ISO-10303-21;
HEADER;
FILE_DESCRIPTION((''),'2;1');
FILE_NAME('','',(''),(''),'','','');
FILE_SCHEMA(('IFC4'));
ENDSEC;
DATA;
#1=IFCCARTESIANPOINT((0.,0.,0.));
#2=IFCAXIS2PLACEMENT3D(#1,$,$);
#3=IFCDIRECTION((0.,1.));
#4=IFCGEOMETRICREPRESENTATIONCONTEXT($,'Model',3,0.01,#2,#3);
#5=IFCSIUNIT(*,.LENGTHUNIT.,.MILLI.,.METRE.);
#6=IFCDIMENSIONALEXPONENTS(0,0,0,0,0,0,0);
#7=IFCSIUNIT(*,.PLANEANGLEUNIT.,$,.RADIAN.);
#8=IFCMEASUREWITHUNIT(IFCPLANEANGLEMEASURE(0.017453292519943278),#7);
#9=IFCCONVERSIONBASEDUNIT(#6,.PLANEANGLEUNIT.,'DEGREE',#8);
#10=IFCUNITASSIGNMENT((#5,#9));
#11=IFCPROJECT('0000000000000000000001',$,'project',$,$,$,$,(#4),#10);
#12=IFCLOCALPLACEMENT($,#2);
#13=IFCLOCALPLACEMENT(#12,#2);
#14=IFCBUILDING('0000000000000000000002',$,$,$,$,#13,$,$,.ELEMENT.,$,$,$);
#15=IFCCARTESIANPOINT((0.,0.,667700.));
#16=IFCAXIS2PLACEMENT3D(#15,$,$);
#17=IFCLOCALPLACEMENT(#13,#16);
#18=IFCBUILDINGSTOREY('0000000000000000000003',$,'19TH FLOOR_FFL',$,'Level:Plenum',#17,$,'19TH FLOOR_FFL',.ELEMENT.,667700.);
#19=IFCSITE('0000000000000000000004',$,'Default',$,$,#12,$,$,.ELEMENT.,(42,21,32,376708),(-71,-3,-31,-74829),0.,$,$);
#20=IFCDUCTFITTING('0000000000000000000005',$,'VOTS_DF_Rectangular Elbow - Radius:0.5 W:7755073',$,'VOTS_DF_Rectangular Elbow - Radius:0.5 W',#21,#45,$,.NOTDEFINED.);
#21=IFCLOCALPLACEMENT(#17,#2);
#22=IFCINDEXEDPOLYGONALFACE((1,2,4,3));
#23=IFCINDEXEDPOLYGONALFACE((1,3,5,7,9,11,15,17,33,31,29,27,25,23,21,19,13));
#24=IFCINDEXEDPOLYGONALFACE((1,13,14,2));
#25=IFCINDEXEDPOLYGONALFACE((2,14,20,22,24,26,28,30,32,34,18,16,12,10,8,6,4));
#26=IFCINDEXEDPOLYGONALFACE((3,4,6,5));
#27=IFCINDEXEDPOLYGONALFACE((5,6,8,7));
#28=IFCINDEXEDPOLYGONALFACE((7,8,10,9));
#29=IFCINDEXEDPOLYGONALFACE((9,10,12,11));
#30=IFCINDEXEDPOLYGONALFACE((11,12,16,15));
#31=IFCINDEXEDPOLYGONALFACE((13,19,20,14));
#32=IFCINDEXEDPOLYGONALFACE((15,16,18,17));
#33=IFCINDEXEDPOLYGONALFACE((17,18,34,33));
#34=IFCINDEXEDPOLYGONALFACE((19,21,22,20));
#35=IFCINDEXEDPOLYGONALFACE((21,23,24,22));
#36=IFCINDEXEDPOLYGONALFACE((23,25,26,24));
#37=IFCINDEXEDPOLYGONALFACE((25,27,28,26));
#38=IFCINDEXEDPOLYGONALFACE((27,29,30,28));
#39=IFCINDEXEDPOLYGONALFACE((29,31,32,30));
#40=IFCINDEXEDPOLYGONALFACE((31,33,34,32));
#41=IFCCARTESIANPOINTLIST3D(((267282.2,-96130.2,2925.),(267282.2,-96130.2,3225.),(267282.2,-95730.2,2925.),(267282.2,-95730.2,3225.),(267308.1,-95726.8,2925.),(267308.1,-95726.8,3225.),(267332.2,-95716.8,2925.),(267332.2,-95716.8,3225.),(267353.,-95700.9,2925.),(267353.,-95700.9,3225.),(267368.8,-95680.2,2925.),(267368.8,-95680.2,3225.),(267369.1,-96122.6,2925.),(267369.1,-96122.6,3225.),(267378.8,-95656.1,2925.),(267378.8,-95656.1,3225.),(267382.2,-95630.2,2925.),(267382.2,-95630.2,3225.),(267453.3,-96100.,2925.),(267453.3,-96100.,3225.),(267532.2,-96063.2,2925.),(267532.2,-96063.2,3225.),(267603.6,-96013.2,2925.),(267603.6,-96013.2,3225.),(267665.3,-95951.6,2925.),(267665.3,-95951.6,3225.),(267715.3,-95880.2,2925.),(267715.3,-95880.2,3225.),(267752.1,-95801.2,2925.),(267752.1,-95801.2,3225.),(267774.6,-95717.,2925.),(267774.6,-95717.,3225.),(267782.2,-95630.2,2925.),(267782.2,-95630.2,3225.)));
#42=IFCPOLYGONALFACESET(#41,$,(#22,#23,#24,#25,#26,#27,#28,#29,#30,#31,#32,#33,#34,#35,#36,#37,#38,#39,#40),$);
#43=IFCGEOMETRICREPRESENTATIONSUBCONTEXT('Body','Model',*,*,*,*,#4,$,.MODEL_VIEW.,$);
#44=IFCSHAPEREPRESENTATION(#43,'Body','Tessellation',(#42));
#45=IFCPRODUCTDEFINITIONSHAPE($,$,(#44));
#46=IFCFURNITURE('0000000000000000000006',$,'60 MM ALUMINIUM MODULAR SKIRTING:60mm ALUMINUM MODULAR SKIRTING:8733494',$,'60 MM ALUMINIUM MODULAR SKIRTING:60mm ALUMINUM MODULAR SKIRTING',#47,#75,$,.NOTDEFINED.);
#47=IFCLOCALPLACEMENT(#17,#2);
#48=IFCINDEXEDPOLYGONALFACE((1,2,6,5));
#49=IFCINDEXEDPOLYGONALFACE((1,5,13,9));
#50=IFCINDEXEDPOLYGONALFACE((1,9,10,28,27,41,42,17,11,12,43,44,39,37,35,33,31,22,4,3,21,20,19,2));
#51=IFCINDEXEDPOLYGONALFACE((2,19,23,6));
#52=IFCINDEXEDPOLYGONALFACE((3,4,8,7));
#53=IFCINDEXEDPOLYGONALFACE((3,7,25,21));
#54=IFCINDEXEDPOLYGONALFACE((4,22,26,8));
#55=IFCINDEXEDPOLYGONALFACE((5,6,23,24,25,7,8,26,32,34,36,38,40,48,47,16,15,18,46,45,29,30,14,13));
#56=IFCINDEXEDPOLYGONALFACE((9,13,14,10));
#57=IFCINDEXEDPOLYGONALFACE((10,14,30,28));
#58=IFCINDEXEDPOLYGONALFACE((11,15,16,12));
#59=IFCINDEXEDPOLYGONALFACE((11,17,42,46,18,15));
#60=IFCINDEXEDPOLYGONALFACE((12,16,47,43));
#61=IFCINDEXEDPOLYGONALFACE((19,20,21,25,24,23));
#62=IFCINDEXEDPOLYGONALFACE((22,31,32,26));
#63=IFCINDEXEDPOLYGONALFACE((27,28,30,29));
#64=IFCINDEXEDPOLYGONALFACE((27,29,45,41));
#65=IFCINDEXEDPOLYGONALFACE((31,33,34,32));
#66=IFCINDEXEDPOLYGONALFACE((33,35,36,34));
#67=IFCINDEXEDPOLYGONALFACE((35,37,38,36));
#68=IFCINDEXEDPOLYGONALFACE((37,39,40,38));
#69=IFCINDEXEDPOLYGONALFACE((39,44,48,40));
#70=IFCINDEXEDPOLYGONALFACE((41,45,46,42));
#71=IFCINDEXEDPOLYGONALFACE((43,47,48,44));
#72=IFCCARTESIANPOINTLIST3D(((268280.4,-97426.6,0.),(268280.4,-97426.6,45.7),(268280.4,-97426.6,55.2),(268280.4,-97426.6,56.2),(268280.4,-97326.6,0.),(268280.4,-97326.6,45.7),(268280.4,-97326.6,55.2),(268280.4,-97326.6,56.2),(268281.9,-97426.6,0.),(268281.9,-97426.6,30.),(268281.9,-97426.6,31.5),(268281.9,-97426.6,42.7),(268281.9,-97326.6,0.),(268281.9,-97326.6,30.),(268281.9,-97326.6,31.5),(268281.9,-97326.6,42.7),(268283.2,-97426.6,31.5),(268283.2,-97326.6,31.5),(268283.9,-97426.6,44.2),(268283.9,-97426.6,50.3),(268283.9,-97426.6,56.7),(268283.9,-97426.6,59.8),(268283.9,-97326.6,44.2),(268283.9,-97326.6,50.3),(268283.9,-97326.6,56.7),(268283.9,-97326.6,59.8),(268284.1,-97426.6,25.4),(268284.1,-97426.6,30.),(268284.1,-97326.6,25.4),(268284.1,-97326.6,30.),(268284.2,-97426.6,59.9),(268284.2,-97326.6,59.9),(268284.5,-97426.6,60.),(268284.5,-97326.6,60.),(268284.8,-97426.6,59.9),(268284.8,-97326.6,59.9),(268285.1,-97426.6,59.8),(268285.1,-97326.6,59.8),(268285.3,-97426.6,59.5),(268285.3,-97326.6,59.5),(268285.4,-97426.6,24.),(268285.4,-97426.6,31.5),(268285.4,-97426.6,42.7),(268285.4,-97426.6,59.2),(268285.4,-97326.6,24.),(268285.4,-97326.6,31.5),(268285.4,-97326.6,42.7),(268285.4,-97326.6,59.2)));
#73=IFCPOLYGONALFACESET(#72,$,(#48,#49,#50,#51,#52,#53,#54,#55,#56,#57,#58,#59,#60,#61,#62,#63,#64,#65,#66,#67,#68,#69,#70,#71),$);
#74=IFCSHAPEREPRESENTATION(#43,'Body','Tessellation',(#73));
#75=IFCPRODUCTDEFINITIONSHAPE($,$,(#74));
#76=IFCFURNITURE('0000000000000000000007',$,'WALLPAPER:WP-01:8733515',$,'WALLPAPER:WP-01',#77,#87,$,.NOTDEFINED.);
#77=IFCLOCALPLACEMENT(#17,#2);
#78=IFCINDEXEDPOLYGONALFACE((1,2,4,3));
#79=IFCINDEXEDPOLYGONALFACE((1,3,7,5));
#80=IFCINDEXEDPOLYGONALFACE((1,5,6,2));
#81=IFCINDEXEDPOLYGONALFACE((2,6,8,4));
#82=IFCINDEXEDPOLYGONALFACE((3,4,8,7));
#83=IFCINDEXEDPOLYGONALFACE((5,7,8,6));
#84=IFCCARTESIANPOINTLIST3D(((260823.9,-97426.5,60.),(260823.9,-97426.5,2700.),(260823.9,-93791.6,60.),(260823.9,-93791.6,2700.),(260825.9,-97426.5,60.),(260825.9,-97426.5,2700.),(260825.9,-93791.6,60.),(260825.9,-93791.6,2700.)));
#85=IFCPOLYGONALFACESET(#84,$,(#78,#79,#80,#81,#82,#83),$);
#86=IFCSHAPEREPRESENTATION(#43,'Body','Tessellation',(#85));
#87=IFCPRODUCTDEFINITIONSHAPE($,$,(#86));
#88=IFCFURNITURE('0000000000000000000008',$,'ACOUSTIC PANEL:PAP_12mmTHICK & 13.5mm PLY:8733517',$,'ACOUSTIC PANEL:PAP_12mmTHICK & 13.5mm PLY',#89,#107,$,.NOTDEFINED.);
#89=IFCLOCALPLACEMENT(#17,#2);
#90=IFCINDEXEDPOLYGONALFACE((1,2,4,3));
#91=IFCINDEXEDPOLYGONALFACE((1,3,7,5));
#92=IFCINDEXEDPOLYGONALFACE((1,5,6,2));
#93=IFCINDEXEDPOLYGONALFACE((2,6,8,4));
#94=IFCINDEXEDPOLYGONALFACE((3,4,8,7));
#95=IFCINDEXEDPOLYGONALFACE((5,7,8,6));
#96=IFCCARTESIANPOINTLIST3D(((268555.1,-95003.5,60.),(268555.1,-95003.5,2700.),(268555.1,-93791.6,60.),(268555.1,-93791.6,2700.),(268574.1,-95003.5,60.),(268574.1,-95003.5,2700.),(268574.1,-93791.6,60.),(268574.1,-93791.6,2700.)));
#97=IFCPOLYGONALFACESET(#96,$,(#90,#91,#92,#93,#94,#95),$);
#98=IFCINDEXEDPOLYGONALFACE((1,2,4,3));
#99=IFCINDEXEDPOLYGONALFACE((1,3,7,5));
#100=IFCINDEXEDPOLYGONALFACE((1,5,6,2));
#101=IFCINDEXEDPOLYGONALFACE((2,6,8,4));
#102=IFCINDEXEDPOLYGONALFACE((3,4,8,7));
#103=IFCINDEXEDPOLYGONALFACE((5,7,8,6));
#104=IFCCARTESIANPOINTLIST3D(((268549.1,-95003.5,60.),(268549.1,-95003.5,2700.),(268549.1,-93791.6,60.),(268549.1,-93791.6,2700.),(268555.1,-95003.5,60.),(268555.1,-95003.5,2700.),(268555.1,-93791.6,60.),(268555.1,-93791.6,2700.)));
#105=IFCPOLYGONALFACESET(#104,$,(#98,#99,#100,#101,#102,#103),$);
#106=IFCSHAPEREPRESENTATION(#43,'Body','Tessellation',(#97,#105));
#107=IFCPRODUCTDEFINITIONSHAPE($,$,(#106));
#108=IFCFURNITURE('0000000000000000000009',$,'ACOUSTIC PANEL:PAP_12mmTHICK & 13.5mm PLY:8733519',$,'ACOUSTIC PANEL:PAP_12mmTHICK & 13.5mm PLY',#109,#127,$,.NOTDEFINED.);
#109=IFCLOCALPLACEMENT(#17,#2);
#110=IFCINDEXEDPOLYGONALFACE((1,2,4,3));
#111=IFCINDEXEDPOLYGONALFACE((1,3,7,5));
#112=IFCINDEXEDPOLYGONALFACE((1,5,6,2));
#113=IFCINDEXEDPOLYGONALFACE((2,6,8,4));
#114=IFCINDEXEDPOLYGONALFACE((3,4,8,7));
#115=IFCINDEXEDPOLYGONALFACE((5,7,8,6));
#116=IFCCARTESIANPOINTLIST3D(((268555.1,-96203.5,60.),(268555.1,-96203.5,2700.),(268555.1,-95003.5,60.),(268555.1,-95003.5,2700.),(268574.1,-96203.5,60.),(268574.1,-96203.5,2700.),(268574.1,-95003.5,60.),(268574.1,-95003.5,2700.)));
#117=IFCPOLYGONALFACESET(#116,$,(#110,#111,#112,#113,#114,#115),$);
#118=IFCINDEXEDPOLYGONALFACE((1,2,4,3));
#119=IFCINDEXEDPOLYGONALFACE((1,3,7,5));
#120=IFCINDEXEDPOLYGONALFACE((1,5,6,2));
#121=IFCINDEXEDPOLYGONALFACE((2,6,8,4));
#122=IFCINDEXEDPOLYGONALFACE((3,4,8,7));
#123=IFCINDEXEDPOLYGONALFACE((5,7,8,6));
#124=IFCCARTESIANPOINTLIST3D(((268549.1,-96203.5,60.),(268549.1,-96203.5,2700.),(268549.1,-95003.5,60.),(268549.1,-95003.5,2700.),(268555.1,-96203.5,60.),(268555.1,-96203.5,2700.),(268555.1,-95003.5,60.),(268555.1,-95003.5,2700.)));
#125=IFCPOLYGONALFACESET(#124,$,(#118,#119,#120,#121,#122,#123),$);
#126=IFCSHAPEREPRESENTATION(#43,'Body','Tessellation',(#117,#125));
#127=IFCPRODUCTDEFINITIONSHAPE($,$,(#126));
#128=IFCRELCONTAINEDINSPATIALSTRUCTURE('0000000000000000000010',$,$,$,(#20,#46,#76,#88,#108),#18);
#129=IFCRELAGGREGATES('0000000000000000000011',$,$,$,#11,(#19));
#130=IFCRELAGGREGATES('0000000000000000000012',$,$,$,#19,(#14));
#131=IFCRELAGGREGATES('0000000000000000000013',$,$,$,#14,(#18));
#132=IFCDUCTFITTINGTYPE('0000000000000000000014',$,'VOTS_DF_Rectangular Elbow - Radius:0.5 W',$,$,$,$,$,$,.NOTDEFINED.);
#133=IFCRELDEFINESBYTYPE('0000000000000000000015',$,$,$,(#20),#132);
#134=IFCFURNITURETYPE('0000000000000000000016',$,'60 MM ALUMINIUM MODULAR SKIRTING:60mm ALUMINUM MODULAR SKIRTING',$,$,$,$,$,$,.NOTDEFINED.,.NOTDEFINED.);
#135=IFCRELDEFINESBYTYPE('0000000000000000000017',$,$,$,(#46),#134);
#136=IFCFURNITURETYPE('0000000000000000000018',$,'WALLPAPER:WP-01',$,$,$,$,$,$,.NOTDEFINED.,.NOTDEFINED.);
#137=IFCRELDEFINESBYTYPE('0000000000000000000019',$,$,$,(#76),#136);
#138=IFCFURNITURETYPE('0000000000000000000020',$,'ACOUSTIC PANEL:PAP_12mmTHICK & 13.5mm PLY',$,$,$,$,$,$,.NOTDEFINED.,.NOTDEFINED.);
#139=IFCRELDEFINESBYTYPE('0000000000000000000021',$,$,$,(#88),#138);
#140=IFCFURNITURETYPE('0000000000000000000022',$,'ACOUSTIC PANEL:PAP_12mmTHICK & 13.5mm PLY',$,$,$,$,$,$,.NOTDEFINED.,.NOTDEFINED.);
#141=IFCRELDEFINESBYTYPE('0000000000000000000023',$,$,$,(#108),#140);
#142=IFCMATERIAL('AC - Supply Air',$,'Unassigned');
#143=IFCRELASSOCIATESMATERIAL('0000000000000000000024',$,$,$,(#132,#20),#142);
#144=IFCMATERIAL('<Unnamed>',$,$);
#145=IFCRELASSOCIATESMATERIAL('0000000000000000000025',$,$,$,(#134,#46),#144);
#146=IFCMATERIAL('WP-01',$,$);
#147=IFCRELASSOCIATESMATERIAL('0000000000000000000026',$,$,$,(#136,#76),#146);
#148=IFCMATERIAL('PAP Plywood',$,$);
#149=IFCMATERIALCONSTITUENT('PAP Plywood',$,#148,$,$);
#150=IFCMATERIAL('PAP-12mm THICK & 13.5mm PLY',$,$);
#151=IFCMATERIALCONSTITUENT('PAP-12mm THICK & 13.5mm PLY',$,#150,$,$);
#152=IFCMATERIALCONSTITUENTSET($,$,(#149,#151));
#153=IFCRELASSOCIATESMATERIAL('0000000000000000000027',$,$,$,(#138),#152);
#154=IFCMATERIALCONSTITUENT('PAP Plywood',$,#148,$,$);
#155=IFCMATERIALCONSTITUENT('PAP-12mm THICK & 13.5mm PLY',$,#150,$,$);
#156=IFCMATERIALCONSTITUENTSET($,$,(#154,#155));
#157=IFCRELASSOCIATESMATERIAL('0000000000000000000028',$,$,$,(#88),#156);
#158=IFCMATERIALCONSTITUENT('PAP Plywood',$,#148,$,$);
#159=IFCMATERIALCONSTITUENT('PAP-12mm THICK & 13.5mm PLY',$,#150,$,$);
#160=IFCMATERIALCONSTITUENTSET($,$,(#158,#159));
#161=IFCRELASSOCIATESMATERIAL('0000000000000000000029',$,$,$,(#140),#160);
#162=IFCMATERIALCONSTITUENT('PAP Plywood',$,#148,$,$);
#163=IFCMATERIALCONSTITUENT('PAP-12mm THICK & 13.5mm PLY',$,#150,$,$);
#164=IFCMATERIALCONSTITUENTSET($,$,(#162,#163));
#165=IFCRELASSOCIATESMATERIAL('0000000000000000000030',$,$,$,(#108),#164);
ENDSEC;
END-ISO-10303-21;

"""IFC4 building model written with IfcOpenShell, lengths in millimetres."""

from ifc_helpers import new_model, entity, si_unit, converted_unit, direction, frame, origin, place, context, subcontext, project, spatial, line, arc, indexed_curve, outline, extrude, source, transform, mapped, material, constituent, constituent_set, type_object, type_shapes, element, save


model = new_model("IFC4")

# Units and contexts
model_context = context("Model", 3, precision=0.01, world=origin(), true_north=direction((0.0, 1.0)))
body_context = subcontext(model_context, "Body", "Model", "MODEL_VIEW")
ifc_project = project(units=[si_unit("LENGTHUNIT", "METRE", prefix="MILLI"), converted_unit("PLANEANGLEUNIT", "DEGREE", entity("IfcPlaneAngleMeasure", 0.017453292519943278), si_unit("PLANEANGLEUNIT", "RADIAN"), dimensions=[0, 0, 0, 0, 0, 0, 0])], contexts=[model_context])

# Site, building, storey
site_placement = place(None, origin())
site = spatial("IfcSite", under=ifc_project, at=site_placement, Name="Default", CompositionType="ELEMENT", RefLatitude=(42, 21, 32, 376708), RefLongitude=(-71, -3, -31, -74829), RefElevation=0.0)
building_placement = place(site_placement, origin())
building = spatial("IfcBuilding", under=site, at=building_placement, CompositionType="ELEMENT")
storey_placement = place(building_placement, frame((0.0, 0.0, 667700.0)))
storey = spatial("IfcBuildingStorey", under=building, at=storey_placement, Name="19TH FLOOR_FFL", ObjectType="Level:Plenum", LongName="19TH FLOOR_FFL", CompositionType="ELEMENT", Elevation=667700.0)

# Shared definitions
ifc_material_1 = material(Name="<Unnamed>")

# Duct fitting
ifc_material_2 = material(Name="AC - Supply Air", Category="Unassigned")
duct_fitting_type_1 = type_object("IfcDuctFittingType", Name="VOTS_DF_Rectangular Elbow - Radius:0.5 W", PredefinedType="NOTDEFINED", material=ifc_material_2)
shared_shape_1 = source(origin(), body_context, "Body", "SweptSolid", [
    extrude(outline(indexed_curve([(-350.0, -150.0), (50.0, -150.0), (79.3, -79.3), (150.0, -50.0), (150.0, 350.0), (-203.6, 203.6)], segments=[line(1, 2), arc(2, 3, 4), line(4, 5), arc(5, 6, 1)], self_intersect=False)), frame((-150.0, 150.0, -150.0), z_axis=(0.0, 0.0, 1.0), x_axis=(-1.0, 0.0, 0.0)), (0.0, 0.0, 1.0), 300.0),
])
type_shapes(duct_fitting_type_1, [shared_shape_1])
duct_fitting_1_placement = place(storey_placement, frame((267582.2, -95930.2, 3075.0)))
element("IfcDuctFitting", 1, at=duct_fitting_1_placement, inside=storey, type_object=duct_fitting_type_1, material=ifc_material_2, Name="VOTS_DF_Rectangular Elbow - Radius:0.5 W:7755073", ObjectType="VOTS_DF_Rectangular Elbow - Radius:0.5 W", PredefinedType="NOTDEFINED", context=body_context, shape_type="MappedRepresentation", body=[
    mapped(shared_shape_1, transform((0.0, 0.0, 0.0), scale=1.0)),
])

# Furniture
furniture_type_1 = type_object("IfcFurnitureType", Name="60 MM ALUMINIUM MODULAR SKIRTING:60mm ALUMINUM MODULAR SKIRTING", AssemblyPlace="NOTDEFINED", PredefinedType="NOTDEFINED", material=ifc_material_1)
shared_shape_2 = source(origin(), body_context, "Body", "SweptSolid", [
    extrude(outline(indexed_curve([(-18.5, -2.7), (-17.5, -2.7), (-19.0, 0.8), (-12.6, 0.8), (-6.5, 0.8), (-8.0, -2.7), (37.7, -2.7), (37.7, -1.2), (7.7, -1.2), (7.7, 1.0), (12.3, 1.0), (13.7, 2.4), (6.2, 2.4), (6.2, 0.2), (6.2, -1.2), (-5.0, -1.2), (-5.0, 2.4), (-21.4, 2.3), (-22.2, 1.8), (-22.0, 0.9)], segments=[line(1, 2, 3, 4, 5, 6, 7, 8, 9, 10, 11, 12, 13, 14, 15, 16, 17, 18), arc(18, 19, 20), line(20, 1)], self_intersect=False)), frame((0.0, -2.4, 37.7), z_axis=(1.0, 0.0, 0.0), x_axis=(0.0, 0.0, -1.0)), (0.0, 0.0, 1.0), 100.0),
])
type_shapes(furniture_type_1, [shared_shape_2])
furniture_1_placement = place(storey_placement, frame((268285.4, -97326.6, 0.0), z_axis=(0.0, 0.0, 1.0), x_axis=(0.0, -1.0, 0.0)))
element("IfcFurniture", 2, at=furniture_1_placement, inside=storey, type_object=furniture_type_1, material=ifc_material_1, Name="60 MM ALUMINIUM MODULAR SKIRTING:60mm ALUMINUM MODULAR SKIRTING:8733494", ObjectType="60 MM ALUMINIUM MODULAR SKIRTING:60mm ALUMINUM MODULAR SKIRTING", PredefinedType="NOTDEFINED", context=body_context, shape_type="MappedRepresentation", body=[
    mapped(shared_shape_2, transform((0.0, 0.0, 0.0), scale=1.0)),
])
ifc_material_3 = material(Name="WP-01")
furniture_type_2 = type_object("IfcFurnitureType", Name="WALLPAPER:WP-01", AssemblyPlace="NOTDEFINED", PredefinedType="NOTDEFINED", material=ifc_material_3)
shared_shape_3 = source(origin(), body_context, "Body", "SweptSolid", [
    extrude(outline(indexed_curve([(-1817.4, -1320.0), (1817.4, -1320.0), (1817.4, 1320.0), (-1817.4, 1320.0), (-1817.4, -1320.0)], self_intersect=False)), frame((0.0, 1320.0, 0.0), z_axis=(0.0, 0.0, 1.0), x_axis=(-1.0, 0.0, 0.0)), (0.0, 0.0, 1.0), 2.0),
])
type_shapes(furniture_type_2, [shared_shape_3])
furniture_2_placement = place(storey_placement, frame((260823.9, -95609.1, 60.0), z_axis=(1.0, 0.0, 0.0), x_axis=(0.0, 1.0, 0.0)))
element("IfcFurniture", 3, at=furniture_2_placement, inside=storey, type_object=furniture_type_2, material=ifc_material_3, Name="WALLPAPER:WP-01:8733515", ObjectType="WALLPAPER:WP-01", PredefinedType="NOTDEFINED", context=body_context, shape_type="MappedRepresentation", body=[
    mapped(shared_shape_3, transform((0.0, 0.0, 0.0), scale=1.0)),
])
ifc_material_4 = material(Name="PAP Plywood")
ifc_constituent_1 = constituent(ifc_material_4, Name="PAP Plywood")
ifc_material_5 = material(Name="PAP-12mm THICK & 13.5mm PLY")
ifc_constituent_2 = constituent(ifc_material_5, Name="PAP-12mm THICK & 13.5mm PLY")
ifc_constituent_set_1 = constituent_set(constituents=[ifc_constituent_1, ifc_constituent_2])
ifc_constituent_3 = constituent(ifc_material_4, Name="PAP Plywood")
ifc_constituent_4 = constituent(ifc_material_5, Name="PAP-12mm THICK & 13.5mm PLY")
ifc_constituent_set_2 = constituent_set(constituents=[ifc_constituent_3, ifc_constituent_4])
furniture_type_3 = type_object("IfcFurnitureType", Name="ACOUSTIC PANEL:PAP_12mmTHICK & 13.5mm PLY", AssemblyPlace="NOTDEFINED", PredefinedType="NOTDEFINED", material=ifc_constituent_set_2)
shared_shape_4 = source(origin(), body_context, "Body", "SweptSolid", [
    extrude(outline(indexed_curve([(-605.9, -1320.0), (605.9, -1320.0), (605.9, 1320.0), (-605.9, 1320.0), (-605.9, -1320.0)], self_intersect=False)), frame((0.0, 1320.0, 0.0), z_axis=(0.0, 0.0, 1.0), x_axis=(-1.0, 0.0, 0.0)), (0.0, 0.0, 1.0), 19.0),
    extrude(outline(indexed_curve([(-605.9, -1320.0), (605.9, -1320.0), (605.9, 1320.0), (-605.9, 1320.0), (-605.9, -1320.0)], self_intersect=False)), frame((0.0, 1320.0, 19.0), z_axis=(0.0, 0.0, 1.0), x_axis=(-1.0, 0.0, 0.0)), (0.0, 0.0, 1.0), 6.0),
])
type_shapes(furniture_type_3, [shared_shape_4])
furniture_3_placement = place(storey_placement, frame((268574.1, -94397.6, 60.0), z_axis=(-1.0, 0.0, 0.0), x_axis=(0.0, -1.0, 0.0)))
element("IfcFurniture", 4, at=furniture_3_placement, inside=storey, type_object=furniture_type_3, material=ifc_constituent_set_1, Name="ACOUSTIC PANEL:PAP_12mmTHICK & 13.5mm PLY:8733517", ObjectType="ACOUSTIC PANEL:PAP_12mmTHICK & 13.5mm PLY", PredefinedType="NOTDEFINED", context=body_context, shape_type="MappedRepresentation", body=[
    mapped(shared_shape_4, transform((0.0, 0.0, 0.0), scale=1.0)),
])
ifc_constituent_5 = constituent(ifc_material_4, Name="PAP Plywood")
ifc_constituent_6 = constituent(ifc_material_5, Name="PAP-12mm THICK & 13.5mm PLY")
ifc_constituent_set_3 = constituent_set(constituents=[ifc_constituent_5, ifc_constituent_6])
ifc_constituent_7 = constituent(ifc_material_4, Name="PAP Plywood")
ifc_constituent_8 = constituent(ifc_material_5, Name="PAP-12mm THICK & 13.5mm PLY")
ifc_constituent_set_4 = constituent_set(constituents=[ifc_constituent_7, ifc_constituent_8])
furniture_type_4 = type_object("IfcFurnitureType", Name="ACOUSTIC PANEL:PAP_12mmTHICK & 13.5mm PLY", AssemblyPlace="NOTDEFINED", PredefinedType="NOTDEFINED", material=ifc_constituent_set_4)
shared_shape_5 = source(origin(), body_context, "Body", "SweptSolid", [
    extrude(outline(indexed_curve([(-1320.0, -600.0), (1320.0, -600.0), (1320.0, 600.0), (-1320.0, 600.0), (-1320.0, -600.0)], self_intersect=False)), frame((0.0, -1320.0, 0.0), z_axis=(0.0, 0.0, 1.0), x_axis=(0.0, 1.0, 0.0)), (0.0, 0.0, 1.0), 19.0),
    extrude(outline(indexed_curve([(-1320.0, -600.0), (1320.0, -600.0), (1320.0, 600.0), (-1320.0, 600.0), (-1320.0, -600.0)], self_intersect=False)), frame((0.0, -1320.0, 19.0), z_axis=(0.0, 0.0, 1.0), x_axis=(0.0, 1.0, 0.0)), (0.0, 0.0, 1.0), 6.0),
])
type_shapes(furniture_type_4, [shared_shape_5])
furniture_4_placement = place(storey_placement, frame((268574.1, -95603.5, 60.0), z_axis=(-1.0, 0.0, 0.0), x_axis=(0.0, 1.0, 0.0)))
element("IfcFurniture", 5, at=furniture_4_placement, inside=storey, type_object=furniture_type_4, material=ifc_constituent_set_3, Name="ACOUSTIC PANEL:PAP_12mmTHICK & 13.5mm PLY:8733519", ObjectType="ACOUSTIC PANEL:PAP_12mmTHICK & 13.5mm PLY", PredefinedType="NOTDEFINED", context=body_context, shape_type="MappedRepresentation", body=[
    mapped(shared_shape_5, transform((0.0, 0.0, 0.0), scale=1.0)),
])

save(model, "model.ifc")
